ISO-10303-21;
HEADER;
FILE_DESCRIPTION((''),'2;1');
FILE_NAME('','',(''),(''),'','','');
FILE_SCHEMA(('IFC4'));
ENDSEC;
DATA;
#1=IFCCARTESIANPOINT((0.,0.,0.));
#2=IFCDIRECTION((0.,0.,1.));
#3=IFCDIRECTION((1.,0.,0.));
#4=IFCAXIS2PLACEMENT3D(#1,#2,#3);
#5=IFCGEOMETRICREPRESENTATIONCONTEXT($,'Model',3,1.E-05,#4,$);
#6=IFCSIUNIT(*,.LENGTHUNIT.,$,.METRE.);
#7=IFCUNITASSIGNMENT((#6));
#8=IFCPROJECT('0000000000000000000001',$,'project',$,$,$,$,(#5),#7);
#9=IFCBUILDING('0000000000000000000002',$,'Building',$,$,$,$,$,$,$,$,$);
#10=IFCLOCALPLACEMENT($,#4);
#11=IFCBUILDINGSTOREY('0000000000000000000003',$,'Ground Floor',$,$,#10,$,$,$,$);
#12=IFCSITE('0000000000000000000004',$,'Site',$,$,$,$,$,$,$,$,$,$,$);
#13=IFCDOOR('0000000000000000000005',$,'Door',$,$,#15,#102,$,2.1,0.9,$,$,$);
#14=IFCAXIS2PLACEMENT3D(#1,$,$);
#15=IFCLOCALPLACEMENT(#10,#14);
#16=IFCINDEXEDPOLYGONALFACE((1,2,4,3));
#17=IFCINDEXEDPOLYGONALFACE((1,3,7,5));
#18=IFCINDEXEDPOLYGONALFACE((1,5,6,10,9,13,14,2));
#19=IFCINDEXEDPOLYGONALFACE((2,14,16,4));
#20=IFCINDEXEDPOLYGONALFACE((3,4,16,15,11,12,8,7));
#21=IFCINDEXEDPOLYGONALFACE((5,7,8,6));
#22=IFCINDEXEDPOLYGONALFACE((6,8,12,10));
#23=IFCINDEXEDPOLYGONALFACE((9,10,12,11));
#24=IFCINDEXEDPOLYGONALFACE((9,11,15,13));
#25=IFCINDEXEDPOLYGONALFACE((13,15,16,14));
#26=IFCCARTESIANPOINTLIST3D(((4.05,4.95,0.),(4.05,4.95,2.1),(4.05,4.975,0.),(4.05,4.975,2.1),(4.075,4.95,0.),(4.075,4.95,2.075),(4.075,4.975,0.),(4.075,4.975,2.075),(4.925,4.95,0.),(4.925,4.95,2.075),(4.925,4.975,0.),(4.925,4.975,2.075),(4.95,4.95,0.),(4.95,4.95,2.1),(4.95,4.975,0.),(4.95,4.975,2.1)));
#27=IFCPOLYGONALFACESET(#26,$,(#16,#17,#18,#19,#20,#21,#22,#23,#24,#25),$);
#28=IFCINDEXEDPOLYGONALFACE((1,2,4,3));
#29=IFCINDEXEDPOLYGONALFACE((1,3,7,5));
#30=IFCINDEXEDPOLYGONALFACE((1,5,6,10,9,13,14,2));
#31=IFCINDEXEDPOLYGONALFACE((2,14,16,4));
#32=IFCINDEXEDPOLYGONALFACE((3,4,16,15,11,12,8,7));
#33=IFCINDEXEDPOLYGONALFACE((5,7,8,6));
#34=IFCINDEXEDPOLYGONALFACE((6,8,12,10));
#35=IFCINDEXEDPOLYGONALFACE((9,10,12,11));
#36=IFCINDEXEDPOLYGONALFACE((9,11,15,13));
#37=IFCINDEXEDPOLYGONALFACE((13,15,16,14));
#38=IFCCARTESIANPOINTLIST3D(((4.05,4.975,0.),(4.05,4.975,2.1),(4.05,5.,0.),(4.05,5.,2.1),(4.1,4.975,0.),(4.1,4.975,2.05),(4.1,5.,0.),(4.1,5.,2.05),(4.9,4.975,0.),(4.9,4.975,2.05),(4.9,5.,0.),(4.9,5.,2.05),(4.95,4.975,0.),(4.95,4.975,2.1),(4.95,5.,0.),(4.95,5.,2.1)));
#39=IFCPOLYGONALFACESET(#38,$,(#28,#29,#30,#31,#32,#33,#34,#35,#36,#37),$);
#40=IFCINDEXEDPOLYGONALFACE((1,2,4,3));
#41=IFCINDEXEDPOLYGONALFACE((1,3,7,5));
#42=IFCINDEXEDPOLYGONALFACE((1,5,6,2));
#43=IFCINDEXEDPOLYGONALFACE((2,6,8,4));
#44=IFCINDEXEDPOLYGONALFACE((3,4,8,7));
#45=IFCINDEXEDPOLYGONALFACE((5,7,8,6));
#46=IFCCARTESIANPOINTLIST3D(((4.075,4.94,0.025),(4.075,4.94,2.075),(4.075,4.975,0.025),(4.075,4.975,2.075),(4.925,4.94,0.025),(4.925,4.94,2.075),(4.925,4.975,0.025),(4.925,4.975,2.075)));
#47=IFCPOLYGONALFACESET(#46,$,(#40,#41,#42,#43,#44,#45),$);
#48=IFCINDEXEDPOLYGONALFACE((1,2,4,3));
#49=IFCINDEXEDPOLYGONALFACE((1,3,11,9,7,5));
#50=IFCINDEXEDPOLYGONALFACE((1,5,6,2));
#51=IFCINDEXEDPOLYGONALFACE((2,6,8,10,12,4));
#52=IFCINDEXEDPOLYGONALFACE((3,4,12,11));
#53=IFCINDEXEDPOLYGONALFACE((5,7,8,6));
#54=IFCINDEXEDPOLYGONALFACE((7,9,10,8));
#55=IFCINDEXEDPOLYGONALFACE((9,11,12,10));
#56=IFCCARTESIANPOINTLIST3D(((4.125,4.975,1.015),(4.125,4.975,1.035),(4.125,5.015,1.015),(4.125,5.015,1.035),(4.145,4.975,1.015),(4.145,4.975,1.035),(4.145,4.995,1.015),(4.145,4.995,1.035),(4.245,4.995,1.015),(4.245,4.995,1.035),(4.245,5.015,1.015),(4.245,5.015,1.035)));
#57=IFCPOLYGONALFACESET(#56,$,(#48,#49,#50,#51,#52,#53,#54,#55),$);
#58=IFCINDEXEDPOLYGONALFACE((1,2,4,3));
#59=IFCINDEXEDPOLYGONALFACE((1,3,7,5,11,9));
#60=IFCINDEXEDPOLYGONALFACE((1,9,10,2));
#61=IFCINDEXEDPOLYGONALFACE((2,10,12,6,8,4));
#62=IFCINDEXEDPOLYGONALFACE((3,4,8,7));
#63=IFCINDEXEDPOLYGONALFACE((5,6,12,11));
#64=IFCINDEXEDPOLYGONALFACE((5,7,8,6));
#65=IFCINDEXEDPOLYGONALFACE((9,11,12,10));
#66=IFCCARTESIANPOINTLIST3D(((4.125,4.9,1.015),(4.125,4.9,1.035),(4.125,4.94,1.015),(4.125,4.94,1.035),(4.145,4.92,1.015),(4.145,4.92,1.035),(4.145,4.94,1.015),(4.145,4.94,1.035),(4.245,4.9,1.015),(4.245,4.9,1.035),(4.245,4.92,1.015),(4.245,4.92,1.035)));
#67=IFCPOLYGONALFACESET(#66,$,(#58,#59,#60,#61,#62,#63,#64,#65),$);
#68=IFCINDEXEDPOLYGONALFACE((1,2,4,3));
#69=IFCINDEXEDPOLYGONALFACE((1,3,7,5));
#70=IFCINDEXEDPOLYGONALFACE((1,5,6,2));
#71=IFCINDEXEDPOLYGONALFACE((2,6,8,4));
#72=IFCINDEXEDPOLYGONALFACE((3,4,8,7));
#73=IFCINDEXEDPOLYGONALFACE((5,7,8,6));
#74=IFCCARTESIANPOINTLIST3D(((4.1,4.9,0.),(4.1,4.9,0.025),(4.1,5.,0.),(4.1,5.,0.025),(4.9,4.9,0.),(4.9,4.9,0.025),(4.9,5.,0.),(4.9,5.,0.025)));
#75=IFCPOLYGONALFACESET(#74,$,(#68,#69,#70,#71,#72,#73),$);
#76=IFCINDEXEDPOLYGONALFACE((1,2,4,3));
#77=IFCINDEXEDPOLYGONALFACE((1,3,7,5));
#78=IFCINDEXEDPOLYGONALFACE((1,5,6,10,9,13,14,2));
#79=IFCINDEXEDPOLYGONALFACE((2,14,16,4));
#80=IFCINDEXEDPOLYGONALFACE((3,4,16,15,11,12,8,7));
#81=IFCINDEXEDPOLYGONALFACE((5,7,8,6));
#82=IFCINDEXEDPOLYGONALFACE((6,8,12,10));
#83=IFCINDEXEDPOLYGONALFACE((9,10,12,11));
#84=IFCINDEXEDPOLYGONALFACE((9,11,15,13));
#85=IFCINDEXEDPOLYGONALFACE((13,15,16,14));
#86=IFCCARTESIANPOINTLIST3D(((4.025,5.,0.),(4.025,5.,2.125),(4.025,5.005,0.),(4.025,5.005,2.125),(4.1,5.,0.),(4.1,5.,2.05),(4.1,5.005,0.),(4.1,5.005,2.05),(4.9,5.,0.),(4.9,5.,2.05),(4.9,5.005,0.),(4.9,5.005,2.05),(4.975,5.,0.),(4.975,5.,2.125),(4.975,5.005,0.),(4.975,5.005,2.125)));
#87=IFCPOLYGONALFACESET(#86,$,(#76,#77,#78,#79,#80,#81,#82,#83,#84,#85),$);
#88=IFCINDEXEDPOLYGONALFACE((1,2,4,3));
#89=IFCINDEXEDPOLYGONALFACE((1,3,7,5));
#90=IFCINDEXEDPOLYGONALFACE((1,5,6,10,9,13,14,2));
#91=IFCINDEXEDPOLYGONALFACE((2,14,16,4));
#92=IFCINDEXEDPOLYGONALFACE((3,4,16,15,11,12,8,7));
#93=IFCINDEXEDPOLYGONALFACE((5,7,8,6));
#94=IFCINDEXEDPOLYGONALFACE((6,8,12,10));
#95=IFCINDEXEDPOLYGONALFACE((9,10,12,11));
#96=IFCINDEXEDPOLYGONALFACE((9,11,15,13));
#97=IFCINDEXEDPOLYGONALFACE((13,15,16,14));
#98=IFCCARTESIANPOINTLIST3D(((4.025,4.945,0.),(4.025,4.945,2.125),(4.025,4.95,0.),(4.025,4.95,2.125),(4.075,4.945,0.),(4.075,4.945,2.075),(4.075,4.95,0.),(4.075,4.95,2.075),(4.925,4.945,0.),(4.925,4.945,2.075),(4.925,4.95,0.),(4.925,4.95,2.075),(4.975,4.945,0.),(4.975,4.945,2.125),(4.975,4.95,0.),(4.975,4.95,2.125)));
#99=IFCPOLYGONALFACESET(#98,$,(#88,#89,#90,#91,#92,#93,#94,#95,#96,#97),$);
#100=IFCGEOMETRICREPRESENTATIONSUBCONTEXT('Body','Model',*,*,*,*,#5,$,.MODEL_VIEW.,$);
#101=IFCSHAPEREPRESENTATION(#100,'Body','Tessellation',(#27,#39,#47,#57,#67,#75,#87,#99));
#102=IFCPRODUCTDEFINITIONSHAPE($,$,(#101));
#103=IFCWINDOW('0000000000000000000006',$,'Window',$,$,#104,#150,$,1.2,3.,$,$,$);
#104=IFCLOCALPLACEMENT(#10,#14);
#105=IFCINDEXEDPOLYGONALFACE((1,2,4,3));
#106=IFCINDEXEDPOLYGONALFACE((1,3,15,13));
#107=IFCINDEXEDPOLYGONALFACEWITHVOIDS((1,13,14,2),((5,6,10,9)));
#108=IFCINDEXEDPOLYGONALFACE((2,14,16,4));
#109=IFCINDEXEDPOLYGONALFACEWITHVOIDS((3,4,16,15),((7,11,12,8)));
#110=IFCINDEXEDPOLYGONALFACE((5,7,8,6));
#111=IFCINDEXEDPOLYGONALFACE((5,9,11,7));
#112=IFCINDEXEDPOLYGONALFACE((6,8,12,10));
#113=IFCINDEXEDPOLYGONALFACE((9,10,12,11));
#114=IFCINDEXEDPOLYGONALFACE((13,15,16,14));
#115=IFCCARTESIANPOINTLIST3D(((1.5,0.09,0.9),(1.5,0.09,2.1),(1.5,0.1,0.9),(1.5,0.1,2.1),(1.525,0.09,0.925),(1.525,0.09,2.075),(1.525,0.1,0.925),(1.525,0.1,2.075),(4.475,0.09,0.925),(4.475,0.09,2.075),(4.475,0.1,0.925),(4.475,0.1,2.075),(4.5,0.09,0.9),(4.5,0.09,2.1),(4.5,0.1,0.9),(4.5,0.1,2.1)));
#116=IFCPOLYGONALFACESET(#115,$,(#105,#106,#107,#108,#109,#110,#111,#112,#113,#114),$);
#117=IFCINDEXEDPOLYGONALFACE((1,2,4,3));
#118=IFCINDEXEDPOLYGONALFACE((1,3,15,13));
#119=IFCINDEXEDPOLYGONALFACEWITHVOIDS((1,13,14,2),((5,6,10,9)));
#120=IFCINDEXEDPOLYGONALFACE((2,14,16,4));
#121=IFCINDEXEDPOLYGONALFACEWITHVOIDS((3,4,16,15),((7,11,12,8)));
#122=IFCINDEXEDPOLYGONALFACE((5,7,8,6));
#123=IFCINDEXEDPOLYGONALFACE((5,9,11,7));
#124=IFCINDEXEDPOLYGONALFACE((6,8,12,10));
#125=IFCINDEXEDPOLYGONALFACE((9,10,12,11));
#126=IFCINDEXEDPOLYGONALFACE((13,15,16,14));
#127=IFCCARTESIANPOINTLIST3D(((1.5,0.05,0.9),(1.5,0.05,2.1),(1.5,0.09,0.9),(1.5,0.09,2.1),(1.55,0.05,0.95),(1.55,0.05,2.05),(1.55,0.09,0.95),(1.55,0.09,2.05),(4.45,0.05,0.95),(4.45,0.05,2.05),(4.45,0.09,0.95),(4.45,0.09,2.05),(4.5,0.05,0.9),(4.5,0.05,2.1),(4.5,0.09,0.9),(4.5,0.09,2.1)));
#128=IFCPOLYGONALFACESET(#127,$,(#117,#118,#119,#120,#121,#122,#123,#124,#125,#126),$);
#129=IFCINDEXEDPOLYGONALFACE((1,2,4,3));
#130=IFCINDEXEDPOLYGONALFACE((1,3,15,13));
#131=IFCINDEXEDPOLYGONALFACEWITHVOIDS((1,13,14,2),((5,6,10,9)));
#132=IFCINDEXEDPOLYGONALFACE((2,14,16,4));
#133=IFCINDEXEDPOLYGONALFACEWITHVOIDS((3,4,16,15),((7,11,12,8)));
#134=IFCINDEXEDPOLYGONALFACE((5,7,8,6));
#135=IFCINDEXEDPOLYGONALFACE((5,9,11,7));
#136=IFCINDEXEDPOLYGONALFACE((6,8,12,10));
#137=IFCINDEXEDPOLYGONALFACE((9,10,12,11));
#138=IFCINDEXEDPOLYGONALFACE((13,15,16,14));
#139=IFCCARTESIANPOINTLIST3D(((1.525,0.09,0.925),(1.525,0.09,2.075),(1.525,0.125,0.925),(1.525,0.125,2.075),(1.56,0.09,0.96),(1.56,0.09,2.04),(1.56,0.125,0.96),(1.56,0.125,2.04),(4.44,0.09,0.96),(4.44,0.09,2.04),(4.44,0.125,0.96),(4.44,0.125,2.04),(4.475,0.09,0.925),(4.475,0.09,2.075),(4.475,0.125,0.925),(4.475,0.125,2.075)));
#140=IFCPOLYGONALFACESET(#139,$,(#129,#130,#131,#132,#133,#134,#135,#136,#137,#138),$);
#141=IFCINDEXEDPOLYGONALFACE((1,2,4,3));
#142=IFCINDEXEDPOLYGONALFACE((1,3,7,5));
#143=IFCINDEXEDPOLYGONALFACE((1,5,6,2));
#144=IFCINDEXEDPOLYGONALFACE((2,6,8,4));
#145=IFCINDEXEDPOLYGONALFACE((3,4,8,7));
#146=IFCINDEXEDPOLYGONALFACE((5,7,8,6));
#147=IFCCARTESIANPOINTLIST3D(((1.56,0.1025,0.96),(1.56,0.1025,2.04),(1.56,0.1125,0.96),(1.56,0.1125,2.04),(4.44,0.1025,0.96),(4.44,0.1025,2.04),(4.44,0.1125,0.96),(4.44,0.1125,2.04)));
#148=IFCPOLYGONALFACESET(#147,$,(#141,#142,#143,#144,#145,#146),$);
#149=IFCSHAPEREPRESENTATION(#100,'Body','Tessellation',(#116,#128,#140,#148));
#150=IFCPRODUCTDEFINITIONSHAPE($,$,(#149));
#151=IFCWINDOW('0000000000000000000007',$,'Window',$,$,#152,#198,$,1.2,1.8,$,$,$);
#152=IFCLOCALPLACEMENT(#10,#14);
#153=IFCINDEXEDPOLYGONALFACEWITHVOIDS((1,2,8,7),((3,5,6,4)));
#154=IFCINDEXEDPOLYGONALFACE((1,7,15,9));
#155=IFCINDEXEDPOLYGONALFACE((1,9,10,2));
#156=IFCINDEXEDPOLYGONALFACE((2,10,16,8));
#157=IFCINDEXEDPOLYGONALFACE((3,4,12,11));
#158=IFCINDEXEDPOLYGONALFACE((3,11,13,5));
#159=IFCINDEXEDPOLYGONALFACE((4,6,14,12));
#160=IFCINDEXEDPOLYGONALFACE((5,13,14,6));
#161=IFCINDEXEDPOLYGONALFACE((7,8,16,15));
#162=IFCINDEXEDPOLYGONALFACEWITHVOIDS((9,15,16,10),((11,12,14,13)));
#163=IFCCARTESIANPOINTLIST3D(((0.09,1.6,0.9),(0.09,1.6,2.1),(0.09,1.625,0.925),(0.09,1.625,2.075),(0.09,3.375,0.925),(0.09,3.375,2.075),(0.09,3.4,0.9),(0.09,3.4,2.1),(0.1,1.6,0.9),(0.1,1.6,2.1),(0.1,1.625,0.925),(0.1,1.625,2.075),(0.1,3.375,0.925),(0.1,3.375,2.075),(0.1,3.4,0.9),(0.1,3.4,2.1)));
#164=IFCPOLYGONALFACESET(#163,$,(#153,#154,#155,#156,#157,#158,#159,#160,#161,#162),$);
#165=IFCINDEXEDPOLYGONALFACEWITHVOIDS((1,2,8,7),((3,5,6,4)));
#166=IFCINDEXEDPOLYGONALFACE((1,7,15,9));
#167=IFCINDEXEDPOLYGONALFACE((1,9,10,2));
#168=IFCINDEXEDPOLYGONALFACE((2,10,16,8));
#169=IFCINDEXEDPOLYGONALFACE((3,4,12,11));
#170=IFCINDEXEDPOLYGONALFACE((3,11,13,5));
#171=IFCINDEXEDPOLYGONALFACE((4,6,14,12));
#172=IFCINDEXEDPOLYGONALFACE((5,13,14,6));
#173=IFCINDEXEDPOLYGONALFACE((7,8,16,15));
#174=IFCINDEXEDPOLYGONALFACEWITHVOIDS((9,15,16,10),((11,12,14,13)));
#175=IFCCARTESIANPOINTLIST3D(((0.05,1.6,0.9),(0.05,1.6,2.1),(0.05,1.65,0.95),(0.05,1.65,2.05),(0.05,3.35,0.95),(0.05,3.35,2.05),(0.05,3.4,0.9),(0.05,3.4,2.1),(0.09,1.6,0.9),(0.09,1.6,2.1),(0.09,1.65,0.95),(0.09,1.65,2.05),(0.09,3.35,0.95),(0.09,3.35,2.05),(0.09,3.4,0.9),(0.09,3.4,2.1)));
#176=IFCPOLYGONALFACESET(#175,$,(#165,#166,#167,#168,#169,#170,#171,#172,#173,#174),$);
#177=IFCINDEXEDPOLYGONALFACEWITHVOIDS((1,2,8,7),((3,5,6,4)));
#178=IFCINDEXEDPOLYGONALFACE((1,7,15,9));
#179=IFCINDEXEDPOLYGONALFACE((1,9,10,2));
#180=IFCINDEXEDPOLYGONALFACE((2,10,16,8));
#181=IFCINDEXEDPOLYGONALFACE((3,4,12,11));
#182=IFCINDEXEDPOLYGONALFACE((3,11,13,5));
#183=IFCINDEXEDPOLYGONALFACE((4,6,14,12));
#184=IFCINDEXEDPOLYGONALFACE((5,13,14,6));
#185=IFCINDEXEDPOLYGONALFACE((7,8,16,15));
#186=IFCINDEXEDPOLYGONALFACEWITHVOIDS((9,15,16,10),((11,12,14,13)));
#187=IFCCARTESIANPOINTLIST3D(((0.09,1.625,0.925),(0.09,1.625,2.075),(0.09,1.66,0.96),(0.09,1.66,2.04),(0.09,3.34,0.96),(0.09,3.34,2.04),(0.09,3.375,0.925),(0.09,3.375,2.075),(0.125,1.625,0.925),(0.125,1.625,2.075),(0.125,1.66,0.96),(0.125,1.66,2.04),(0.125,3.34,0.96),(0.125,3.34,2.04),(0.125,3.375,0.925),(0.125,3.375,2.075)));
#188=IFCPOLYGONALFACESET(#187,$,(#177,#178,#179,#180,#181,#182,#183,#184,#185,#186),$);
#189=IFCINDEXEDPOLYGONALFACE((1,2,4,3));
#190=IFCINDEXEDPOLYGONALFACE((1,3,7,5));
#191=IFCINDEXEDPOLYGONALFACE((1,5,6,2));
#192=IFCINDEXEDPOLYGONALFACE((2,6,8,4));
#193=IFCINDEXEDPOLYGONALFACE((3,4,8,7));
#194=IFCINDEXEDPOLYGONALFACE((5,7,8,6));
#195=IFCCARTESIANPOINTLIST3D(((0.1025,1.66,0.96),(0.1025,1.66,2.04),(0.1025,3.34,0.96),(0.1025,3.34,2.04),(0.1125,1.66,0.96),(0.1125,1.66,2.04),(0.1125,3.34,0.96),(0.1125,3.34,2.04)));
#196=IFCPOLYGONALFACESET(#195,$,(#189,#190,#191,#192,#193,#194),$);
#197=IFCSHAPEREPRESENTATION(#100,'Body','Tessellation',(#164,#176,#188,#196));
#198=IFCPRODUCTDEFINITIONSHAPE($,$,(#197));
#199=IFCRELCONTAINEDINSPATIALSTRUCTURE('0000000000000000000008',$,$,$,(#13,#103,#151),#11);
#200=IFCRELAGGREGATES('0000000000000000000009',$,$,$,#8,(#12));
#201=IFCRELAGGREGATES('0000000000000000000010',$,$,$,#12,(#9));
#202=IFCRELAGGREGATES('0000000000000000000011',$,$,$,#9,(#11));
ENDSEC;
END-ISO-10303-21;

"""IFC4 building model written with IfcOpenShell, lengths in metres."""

from ifc_helpers import new_model, si_unit, frame, origin_with_axes, place, context, subcontext, project, spatial, line, indexed_curve, outline, extrude, element, save


model = new_model("IFC4")

# Units and contexts
model_context = context("Model", 3, precision=1e-05, world=origin_with_axes())
body_context = subcontext(model_context, "Body", "Model", "MODEL_VIEW")
ifc_project = project(units=[si_unit("LENGTHUNIT", "METRE")], contexts=[model_context])

# Site, building, storey
site = spatial("IfcSite", under=ifc_project, Name="Site")
building = spatial("IfcBuilding", under=site, Name="Building")
storey_placement = place(None, origin_with_axes())
storey = spatial("IfcBuildingStorey", under=building, at=storey_placement, Name="Ground Floor")

# Door
door_1_placement = place(storey_placement, frame((4.95, 5.0, 0.0), z_axis=(0.0, 0.0, 1.0), x_axis=(-1.0, 0.0, 0.0)))
element("IfcDoor", 1, at=door_1_placement, inside=storey, Name="Door", OverallHeight=2.1, OverallWidth=0.9, context=body_context, shape_type="SweptSolid", body=[
    extrude(outline(indexed_curve([(0.0, 0.0), (0.0, 2.1), (0.9, 2.1), (0.9, 0.0), (0.875, 0.0), (0.875, 2.075), (0.025, 2.075), (0.025, 0.0)], segments=[line(1, 2, 3, 4, 5, 6, 7, 8, 1)])), frame((0.0, 0.025, 0.0), z_axis=(0.0, -1.0, 0.0), x_axis=(1.0, 0.0, 0.0)), (0.0, 0.0, -1.0), 0.025),
    extrude(outline(indexed_curve([(0.0, 0.0), (0.0, 2.1), (0.9, 2.1), (0.9, 0.0), (0.85, 0.0), (0.85, 2.05), (0.05, 2.05), (0.05, 0.0)], segments=[line(1, 2, 3, 4, 5, 6, 7, 8, 1)])), frame((0.0, 0.0, 0.0), z_axis=(0.0, -1.0, 0.0), x_axis=(1.0, 0.0, 0.0)), (0.0, 0.0, -1.0), 0.025),
    extrude(outline(indexed_curve([(0.0, 0.0), (0.85, 0.0), (0.85, 0.035), (0.0, 0.035)], segments=[line(1, 2, 3, 4, 1)])), frame((0.025, 0.025, 0.025), z_axis=(0.0, 0.0, 1.0), x_axis=(1.0, 0.0, 0.0)), (0.0, 0.0, 1.0), 2.05),
    extrude(outline(indexed_curve([(0.0, 0.0), (0.0, -0.04), (-0.12, -0.04), (-0.12, -0.02), (-0.02, -0.02), (-0.02, 0.0)], segments=[line(1, 2, 3, 4, 5, 6, 1)])), frame((0.825, 0.025, 1.015), z_axis=(0.0, 0.0, 1.0), x_axis=(1.0, 0.0, 0.0)), (0.0, 0.0, 1.0), 0.02),
    extrude(outline(indexed_curve([(0.0, 0.0), (0.0, 0.04), (-0.12, 0.04), (-0.12, 0.02), (-0.02, 0.02), (-0.02, 0.0)], segments=[line(1, 2, 3, 4, 5, 6, 1)])), frame((0.825, 0.06, 1.015), z_axis=(0.0, 0.0, 1.0), x_axis=(1.0, 0.0, 0.0)), (0.0, 0.0, 1.0), 0.02),
    extrude(outline(indexed_curve([(0.0, 0.0), (0.8, 0.0), (0.8, 0.1), (0.0, 0.1)], segments=[line(1, 2, 3, 4, 1)])), frame((0.05, 0.0, 0.0), z_axis=(0.0, 0.0, 1.0), x_axis=(1.0, 0.0, 0.0)), (0.0, 0.0, 1.0), 0.025),
    extrude(outline(indexed_curve([(0.0, 0.0), (0.0, 2.125), (0.95, 2.125), (0.95, 0.0), (0.875, 0.0), (0.875, 2.05), (0.075, 2.05), (0.075, 0.0)], segments=[line(1, 2, 3, 4, 5, 6, 7, 8, 1)])), frame((-0.025, -0.005, 0.0), z_axis=(0.0, -1.0, 0.0), x_axis=(1.0, 0.0, 0.0)), (0.0, 0.0, -1.0), 0.005),
    extrude(outline(indexed_curve([(0.0, 0.0), (0.0, 2.125), (0.95, 2.125), (0.95, 0.0), (0.9, 0.0), (0.9, 2.075), (0.05, 2.075), (0.05, 0.0)], segments=[line(1, 2, 3, 4, 5, 6, 7, 8, 1)])), frame((-0.025, 0.05, 0.0), z_axis=(0.0, -1.0, 0.0), x_axis=(1.0, 0.0, 0.0)), (0.0, 0.0, -1.0), 0.005),
])

# Windows
window_1_placement = place(storey_placement, frame((1.5, 0.0, 0.9), z_axis=(0.0, 0.0, 1.0), x_axis=(1.0, 0.0, 0.0)))
element("IfcWindow", 2, at=window_1_placement, inside=storey, Name="Window", OverallHeight=1.2, OverallWidth=3.0, context=body_context, shape_type="SweptSolid", body=[
    extrude(outline(indexed_curve([(0.0, 0.0), (3.0, 0.0), (3.0, 1.2), (0.0, 1.2)], segments=[line(1, 2, 3, 4, 1)]), holes=[indexed_curve([(0.025, 0.025), (2.975, 0.025), (2.975, 1.175), (0.025, 1.175)], segments=[line(1, 2, 3, 4, 1)])]), frame((0.0, 0.09, 0.0), z_axis=(0.0, -1.0, 0.0), x_axis=(1.0, 0.0, 0.0)), (0.0, 0.0, -1.0), 0.01),
    extrude(outline(indexed_curve([(0.0, 0.0), (3.0, 0.0), (3.0, 1.2), (0.0, 1.2)], segments=[line(1, 2, 3, 4, 1)]), holes=[indexed_curve([(0.05, 0.05), (2.95, 0.05), (2.95, 1.15), (0.05, 1.15)], segments=[line(1, 2, 3, 4, 1)])]), frame((0.0, 0.05, 0.0), z_axis=(0.0, -1.0, 0.0), x_axis=(1.0, 0.0, 0.0)), (0.0, 0.0, -1.0), 0.04),
    extrude(outline(indexed_curve([(0.0, 0.0), (2.95, 0.0), (2.95, 1.15), (0.0, 1.15)], segments=[line(1, 2, 3, 4, 1)]), holes=[indexed_curve([(0.035, 0.035), (2.915, 0.035), (2.915, 1.115), (0.035, 1.115)], segments=[line(1, 2, 3, 4, 1)])]), frame((0.025, 0.09, 0.025), z_axis=(0.0, -1.0, 0.0), x_axis=(1.0, 0.0, 0.0)), (0.0, 0.0, -1.0), 0.035),
    extrude(outline(indexed_curve([(0.035, 0.035), (2.915, 0.035), (2.915, 1.115), (0.035, 1.115)], segments=[line(1, 2, 3, 4, 1)])), frame((0.025, 0.1025, 0.025), z_axis=(0.0, -1.0, 0.0), x_axis=(1.0, 0.0, 0.0)), (0.0, 0.0, -1.0), 0.01),
])
window_2_placement = place(storey_placement, frame((0.0, 3.4, 0.9), z_axis=(0.0, 0.0, 1.0), x_axis=(0.0, -1.0, 0.0)))
element("IfcWindow", 3, at=window_2_placement, inside=storey, Name="Window", OverallHeight=1.2, OverallWidth=1.8, context=body_context, shape_type="SweptSolid", body=[
    extrude(outline(indexed_curve([(0.0, 0.0), (1.8, 0.0), (1.8, 1.2), (0.0, 1.2)], segments=[line(1, 2, 3, 4, 1)]), holes=[indexed_curve([(0.025, 0.025), (1.775, 0.025), (1.775, 1.175), (0.025, 1.175)], segments=[line(1, 2, 3, 4, 1)])]), frame((0.0, 0.09, 0.0), z_axis=(0.0, -1.0, 0.0), x_axis=(1.0, 0.0, 0.0)), (0.0, 0.0, -1.0), 0.01),
    extrude(outline(indexed_curve([(0.0, 0.0), (1.8, 0.0), (1.8, 1.2), (0.0, 1.2)], segments=[line(1, 2, 3, 4, 1)]), holes=[indexed_curve([(0.05, 0.05), (1.75, 0.05), (1.75, 1.15), (0.05, 1.15)], segments=[line(1, 2, 3, 4, 1)])]), frame((0.0, 0.05, 0.0), z_axis=(0.0, -1.0, 0.0), x_axis=(1.0, 0.0, 0.0)), (0.0, 0.0, -1.0), 0.04),
    extrude(outline(indexed_curve([(0.0, 0.0), (1.75, 0.0), (1.75, 1.15), (0.0, 1.15)], segments=[line(1, 2, 3, 4, 1)]), holes=[indexed_curve([(0.035, 0.035), (1.715, 0.035), (1.715, 1.115), (0.035, 1.115)], segments=[line(1, 2, 3, 4, 1)])]), frame((0.025, 0.09, 0.025), z_axis=(0.0, -1.0, 0.0), x_axis=(1.0, 0.0, 0.0)), (0.0, 0.0, -1.0), 0.035),
    extrude(outline(indexed_curve([(0.035, 0.035), (1.715, 0.035), (1.715, 1.115), (0.035, 1.115)], segments=[line(1, 2, 3, 4, 1)])), frame((0.025, 0.1025, 0.025), z_axis=(0.0, -1.0, 0.0), x_axis=(1.0, 0.0, 0.0)), (0.0, 0.0, -1.0), 0.01),
])

save(model, "model.ifc")
